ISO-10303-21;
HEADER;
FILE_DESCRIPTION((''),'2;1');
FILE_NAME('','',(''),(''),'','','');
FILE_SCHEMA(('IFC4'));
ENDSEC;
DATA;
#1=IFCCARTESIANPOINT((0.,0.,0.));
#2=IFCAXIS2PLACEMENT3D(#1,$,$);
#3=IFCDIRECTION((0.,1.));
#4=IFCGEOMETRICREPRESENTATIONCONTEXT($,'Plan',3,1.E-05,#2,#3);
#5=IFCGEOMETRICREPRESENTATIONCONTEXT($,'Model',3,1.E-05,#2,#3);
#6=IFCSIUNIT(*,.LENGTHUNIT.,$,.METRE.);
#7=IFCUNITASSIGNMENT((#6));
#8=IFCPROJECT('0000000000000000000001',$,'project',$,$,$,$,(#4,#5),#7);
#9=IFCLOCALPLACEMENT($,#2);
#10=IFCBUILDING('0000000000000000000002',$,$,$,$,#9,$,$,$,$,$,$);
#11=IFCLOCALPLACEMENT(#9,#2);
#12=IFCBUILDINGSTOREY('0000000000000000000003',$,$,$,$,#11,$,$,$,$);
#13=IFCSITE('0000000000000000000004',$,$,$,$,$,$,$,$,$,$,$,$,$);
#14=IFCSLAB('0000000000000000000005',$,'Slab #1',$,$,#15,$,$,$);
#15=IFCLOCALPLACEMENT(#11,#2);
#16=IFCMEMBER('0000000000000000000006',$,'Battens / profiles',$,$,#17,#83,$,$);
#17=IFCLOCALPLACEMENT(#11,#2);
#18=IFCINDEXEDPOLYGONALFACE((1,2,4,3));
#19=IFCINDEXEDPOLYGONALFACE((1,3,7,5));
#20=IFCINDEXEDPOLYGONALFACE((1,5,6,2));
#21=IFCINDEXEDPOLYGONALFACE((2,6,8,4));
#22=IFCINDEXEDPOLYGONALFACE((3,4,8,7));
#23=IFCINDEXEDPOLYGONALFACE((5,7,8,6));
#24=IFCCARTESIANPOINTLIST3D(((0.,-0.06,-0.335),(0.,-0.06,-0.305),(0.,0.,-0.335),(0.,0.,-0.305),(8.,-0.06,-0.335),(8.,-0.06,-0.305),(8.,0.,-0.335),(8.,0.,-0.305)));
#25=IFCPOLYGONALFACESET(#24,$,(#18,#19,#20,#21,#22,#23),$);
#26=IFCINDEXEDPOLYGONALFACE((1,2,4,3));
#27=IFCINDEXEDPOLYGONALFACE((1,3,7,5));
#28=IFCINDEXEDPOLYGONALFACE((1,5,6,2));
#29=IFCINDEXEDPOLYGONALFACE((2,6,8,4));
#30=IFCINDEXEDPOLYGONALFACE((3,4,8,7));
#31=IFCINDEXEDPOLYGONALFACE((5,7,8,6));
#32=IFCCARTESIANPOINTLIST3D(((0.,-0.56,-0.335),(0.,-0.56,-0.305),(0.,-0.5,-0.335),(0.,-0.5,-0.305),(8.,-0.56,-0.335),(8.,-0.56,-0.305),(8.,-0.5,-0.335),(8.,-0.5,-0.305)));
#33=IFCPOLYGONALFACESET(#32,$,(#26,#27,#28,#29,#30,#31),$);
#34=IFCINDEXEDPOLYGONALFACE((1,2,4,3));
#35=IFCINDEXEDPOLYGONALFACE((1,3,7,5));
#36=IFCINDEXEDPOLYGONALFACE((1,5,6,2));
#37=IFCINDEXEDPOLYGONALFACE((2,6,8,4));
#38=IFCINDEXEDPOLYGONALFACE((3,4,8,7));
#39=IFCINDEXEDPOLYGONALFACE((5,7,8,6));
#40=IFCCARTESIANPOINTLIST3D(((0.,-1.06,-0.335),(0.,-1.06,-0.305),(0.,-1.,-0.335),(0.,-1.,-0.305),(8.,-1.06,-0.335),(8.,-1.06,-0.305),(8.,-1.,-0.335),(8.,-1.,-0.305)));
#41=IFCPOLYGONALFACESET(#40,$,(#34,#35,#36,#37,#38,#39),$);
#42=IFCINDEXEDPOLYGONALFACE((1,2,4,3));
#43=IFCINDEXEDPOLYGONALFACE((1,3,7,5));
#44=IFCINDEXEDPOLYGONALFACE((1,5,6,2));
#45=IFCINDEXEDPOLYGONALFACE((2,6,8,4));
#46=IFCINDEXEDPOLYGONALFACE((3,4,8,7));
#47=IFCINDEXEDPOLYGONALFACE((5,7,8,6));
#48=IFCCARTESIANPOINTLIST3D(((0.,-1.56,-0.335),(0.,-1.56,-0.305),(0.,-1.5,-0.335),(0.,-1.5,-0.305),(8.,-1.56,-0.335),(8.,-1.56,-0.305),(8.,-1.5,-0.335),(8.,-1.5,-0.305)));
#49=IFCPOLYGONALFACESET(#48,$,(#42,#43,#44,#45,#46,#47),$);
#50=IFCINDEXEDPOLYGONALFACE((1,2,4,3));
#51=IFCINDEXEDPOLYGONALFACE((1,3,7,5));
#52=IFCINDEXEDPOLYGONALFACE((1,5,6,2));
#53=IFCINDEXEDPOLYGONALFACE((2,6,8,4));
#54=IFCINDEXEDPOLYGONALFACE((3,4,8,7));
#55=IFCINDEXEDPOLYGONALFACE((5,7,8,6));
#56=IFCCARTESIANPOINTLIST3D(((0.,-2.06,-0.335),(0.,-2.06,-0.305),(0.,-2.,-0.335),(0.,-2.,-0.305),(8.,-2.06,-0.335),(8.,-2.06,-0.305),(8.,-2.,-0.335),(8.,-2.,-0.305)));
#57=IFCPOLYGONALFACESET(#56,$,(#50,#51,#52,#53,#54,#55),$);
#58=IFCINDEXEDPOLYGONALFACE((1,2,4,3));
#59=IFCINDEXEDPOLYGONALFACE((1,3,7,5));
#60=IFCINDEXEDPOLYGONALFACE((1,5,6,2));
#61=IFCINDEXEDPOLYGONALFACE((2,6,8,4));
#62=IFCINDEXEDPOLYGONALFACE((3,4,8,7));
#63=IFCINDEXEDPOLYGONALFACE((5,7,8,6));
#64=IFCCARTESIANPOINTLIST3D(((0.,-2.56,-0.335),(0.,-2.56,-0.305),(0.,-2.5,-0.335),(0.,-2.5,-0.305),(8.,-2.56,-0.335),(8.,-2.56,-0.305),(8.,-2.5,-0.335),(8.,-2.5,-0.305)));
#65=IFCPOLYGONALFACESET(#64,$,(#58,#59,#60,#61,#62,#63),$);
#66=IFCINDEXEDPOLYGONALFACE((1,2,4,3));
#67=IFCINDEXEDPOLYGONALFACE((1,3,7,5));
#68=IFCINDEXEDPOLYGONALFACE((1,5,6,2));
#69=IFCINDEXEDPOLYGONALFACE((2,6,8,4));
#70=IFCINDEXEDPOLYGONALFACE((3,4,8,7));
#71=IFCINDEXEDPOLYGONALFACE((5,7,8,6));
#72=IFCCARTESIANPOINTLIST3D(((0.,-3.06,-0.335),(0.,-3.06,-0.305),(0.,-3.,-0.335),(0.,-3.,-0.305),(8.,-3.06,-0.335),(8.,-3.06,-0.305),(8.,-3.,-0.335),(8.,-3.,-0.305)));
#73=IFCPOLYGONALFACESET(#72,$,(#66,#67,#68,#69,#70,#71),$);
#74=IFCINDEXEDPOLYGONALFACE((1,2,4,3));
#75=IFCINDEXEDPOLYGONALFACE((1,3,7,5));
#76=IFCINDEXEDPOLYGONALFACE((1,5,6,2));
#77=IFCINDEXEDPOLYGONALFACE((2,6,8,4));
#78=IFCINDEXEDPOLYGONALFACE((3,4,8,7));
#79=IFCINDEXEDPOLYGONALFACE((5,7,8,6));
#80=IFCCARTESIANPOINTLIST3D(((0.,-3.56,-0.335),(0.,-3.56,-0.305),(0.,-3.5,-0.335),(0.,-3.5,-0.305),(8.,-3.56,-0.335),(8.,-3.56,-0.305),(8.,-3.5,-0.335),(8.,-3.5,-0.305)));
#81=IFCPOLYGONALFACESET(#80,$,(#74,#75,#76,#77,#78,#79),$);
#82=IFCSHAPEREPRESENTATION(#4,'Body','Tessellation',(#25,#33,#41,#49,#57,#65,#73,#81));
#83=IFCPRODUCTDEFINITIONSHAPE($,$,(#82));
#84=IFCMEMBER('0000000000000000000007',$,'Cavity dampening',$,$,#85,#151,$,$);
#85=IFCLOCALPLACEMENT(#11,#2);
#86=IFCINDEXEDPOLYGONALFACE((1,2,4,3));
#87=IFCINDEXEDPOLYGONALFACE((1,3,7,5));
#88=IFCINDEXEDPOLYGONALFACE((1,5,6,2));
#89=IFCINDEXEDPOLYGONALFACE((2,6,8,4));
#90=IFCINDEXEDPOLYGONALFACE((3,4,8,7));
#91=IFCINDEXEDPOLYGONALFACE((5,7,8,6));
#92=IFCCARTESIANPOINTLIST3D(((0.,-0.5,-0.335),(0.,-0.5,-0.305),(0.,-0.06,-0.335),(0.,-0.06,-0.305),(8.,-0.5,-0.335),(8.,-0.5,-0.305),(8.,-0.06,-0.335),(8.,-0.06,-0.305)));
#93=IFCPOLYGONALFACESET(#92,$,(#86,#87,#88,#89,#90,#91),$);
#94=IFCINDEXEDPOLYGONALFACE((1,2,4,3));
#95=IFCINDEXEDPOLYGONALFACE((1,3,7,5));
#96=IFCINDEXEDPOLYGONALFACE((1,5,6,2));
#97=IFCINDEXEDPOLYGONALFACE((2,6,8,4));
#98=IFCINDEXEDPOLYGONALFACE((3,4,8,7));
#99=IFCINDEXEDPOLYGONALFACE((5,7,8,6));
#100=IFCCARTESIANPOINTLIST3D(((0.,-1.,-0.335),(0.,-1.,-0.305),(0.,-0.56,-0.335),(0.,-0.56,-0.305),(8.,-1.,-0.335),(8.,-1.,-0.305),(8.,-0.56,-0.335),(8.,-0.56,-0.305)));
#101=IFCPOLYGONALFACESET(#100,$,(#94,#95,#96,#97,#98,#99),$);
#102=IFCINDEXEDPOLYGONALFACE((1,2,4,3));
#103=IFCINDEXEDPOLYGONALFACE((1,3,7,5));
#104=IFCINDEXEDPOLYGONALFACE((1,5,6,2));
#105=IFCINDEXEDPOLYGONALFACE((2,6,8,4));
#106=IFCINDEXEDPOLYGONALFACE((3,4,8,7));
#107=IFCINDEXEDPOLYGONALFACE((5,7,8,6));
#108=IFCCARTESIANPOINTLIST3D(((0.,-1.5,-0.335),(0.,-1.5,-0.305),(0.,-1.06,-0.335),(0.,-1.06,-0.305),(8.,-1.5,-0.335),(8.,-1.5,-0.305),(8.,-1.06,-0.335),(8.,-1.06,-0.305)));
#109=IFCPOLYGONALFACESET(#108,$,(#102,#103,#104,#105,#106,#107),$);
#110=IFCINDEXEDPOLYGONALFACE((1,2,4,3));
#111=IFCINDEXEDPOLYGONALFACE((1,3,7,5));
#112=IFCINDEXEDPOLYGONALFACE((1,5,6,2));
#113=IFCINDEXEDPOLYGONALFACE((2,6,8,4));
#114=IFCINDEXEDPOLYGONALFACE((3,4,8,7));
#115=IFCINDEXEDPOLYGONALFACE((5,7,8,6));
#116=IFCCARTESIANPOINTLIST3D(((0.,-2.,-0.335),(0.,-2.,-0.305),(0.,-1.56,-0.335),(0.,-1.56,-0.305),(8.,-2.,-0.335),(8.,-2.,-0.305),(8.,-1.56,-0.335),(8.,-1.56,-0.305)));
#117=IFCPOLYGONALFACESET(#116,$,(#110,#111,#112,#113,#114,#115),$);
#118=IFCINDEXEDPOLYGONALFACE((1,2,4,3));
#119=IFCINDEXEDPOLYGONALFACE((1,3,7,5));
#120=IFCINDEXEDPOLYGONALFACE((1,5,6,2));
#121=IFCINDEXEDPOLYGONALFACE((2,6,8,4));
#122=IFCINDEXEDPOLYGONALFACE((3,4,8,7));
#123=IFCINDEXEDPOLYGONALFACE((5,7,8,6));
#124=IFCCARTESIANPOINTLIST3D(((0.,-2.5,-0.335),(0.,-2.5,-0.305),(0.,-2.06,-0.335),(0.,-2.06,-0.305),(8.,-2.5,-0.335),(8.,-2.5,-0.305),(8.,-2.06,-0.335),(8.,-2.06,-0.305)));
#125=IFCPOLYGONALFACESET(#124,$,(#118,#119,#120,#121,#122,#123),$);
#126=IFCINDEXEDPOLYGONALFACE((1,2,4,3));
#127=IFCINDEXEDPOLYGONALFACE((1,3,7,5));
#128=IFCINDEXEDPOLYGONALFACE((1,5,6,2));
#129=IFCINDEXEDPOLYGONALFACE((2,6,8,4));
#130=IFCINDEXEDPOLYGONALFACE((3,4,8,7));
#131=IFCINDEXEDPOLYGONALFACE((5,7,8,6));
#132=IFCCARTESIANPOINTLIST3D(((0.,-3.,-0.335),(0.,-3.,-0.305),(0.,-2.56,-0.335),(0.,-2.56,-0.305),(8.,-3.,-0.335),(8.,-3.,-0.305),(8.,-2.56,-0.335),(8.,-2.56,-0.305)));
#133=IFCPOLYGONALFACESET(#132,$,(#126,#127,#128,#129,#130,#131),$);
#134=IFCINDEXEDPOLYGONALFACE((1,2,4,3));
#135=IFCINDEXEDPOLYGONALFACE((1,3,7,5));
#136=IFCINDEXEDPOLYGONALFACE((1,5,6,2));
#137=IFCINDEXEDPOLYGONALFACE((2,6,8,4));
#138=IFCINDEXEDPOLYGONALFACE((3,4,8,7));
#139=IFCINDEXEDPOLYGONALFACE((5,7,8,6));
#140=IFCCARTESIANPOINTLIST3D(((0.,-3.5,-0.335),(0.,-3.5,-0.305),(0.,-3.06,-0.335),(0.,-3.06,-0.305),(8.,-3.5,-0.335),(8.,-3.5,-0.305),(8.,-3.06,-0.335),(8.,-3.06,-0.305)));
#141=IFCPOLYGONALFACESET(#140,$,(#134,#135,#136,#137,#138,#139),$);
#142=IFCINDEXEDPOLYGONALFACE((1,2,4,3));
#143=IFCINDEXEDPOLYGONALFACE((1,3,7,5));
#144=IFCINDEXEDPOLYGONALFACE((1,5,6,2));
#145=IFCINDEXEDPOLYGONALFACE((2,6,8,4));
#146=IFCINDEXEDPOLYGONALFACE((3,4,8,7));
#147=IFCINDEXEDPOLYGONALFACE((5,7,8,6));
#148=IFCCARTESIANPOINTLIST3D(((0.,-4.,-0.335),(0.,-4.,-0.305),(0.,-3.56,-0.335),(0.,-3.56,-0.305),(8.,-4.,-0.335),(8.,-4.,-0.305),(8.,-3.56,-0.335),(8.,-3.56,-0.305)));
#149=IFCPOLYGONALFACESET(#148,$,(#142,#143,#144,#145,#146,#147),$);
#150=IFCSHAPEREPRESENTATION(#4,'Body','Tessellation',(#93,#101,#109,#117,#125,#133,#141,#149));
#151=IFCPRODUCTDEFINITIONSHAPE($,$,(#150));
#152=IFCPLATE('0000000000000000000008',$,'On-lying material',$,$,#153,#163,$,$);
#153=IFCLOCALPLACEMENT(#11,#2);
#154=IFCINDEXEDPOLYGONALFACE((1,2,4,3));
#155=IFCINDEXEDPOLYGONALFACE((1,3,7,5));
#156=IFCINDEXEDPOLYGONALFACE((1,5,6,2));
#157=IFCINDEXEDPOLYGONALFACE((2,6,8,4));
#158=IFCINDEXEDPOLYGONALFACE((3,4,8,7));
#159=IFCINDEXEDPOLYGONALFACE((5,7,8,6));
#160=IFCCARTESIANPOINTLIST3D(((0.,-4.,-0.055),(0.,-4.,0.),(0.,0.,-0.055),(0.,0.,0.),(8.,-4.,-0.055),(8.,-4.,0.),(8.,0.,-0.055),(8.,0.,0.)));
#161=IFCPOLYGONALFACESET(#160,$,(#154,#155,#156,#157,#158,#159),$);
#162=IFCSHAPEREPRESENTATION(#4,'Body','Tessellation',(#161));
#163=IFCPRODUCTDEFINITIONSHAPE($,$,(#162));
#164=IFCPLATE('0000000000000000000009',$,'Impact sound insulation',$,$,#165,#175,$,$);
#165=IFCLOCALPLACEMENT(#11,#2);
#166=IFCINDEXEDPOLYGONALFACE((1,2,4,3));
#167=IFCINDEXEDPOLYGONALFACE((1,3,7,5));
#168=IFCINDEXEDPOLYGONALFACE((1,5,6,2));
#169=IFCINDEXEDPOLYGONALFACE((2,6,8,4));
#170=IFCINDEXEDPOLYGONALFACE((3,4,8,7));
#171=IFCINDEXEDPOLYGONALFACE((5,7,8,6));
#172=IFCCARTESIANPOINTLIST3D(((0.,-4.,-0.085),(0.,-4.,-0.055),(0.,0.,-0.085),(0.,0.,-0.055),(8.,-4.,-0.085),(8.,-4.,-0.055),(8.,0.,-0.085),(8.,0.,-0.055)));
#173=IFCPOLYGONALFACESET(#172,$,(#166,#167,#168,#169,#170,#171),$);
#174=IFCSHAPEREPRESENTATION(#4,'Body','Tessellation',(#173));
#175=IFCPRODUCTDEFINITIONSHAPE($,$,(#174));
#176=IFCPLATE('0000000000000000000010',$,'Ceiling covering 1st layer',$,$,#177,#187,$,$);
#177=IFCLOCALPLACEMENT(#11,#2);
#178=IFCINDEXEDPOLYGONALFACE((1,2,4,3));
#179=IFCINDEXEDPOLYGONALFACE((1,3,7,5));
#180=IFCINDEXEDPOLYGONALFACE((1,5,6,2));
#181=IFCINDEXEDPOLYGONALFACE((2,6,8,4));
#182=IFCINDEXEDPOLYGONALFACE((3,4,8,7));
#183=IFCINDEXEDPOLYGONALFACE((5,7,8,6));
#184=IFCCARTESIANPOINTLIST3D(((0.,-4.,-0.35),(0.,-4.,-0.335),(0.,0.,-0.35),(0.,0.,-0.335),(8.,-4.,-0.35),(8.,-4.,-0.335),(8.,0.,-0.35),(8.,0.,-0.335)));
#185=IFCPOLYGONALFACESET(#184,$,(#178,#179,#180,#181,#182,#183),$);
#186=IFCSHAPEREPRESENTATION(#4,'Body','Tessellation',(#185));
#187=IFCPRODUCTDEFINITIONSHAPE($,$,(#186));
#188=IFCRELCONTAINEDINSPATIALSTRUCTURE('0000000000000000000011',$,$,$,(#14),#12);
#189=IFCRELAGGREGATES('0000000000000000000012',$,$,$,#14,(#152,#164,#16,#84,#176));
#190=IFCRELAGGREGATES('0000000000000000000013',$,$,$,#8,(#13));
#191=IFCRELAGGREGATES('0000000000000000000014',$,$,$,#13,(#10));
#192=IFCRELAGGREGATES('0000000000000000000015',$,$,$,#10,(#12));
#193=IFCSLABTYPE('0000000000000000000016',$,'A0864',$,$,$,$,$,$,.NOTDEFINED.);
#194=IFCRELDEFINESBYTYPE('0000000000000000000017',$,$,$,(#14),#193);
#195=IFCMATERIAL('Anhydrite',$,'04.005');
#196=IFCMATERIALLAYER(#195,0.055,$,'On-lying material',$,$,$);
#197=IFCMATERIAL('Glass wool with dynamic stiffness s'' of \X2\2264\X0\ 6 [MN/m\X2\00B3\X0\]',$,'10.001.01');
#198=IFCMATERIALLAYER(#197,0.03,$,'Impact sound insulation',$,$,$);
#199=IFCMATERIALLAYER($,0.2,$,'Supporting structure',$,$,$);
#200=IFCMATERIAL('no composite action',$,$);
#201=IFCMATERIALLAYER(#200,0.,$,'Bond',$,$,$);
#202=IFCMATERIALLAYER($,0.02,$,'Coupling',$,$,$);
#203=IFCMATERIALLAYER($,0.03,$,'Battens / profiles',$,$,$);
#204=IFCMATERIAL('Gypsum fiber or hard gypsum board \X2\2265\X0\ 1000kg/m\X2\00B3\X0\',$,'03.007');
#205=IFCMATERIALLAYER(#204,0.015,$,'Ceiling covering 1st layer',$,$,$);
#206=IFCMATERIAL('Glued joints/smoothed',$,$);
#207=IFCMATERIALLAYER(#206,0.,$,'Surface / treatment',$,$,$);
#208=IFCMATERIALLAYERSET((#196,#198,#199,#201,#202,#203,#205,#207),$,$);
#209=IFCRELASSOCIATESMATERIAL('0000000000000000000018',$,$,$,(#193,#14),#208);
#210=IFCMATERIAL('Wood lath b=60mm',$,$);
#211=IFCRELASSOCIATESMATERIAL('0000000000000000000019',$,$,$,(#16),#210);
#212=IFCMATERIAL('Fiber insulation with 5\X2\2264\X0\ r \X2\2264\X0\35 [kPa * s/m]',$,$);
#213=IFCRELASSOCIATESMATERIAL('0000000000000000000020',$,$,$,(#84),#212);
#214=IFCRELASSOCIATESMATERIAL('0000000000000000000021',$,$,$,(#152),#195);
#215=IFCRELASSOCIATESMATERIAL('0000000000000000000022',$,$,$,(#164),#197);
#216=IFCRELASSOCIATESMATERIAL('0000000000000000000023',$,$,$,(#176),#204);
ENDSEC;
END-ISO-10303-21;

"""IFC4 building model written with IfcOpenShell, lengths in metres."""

from ifc_helpers import new_model, si_unit, direction, frame, frame_2d, origin, origin_with_axes, place, context, project, spatial, rectangle, extrude, material, layer, layer_set, type_object, element, aggregate, save


model = new_model("IFC4")

# Units and contexts
plan_context = context("Plan", 3, precision=1e-05, world=origin(), true_north=direction((0.0, 1.0)))
model_context = context("Model", 3, precision=1e-05, world=origin(), true_north=direction((0.0, 1.0)))
ifc_project = project(units=[si_unit("LENGTHUNIT", "METRE")], contexts=[plan_context, model_context])

# Site, building, storey
site = spatial("IfcSite", under=ifc_project)
building_placement = place(None, origin())
building = spatial("IfcBuilding", under=site, at=building_placement)
storey_placement = place(building_placement, origin())
storey = spatial("IfcBuildingStorey", under=building, at=storey_placement)

# Slab, members, plates
ifc_material_1 = material(Name="Anhydrite", Category="04.005")
ifc_layer_1 = layer(ifc_material_1, 0.055, Name="On-lying material")
ifc_material_2 = material(Name="Glass wool with dynamic stiffness s' of ≤ 6 [MN/m³]", Category="10.001.01")
ifc_layer_2 = layer(ifc_material_2, 0.03, Name="Impact sound insulation")
ifc_layer_3 = layer(None, 0.2, Name="Supporting structure")
ifc_material_3 = material(Name="no composite action")
ifc_layer_4 = layer(ifc_material_3, 0.0, Name="Bond")
ifc_layer_5 = layer(None, 0.02, Name="Coupling")
ifc_layer_6 = layer(None, 0.03, Name="Battens / profiles")
ifc_material_4 = material(Name="Gypsum fiber or hard gypsum board ≥ 1000kg/m³", Category="03.007")
ifc_layer_7 = layer(ifc_material_4, 0.015, Name="Ceiling covering 1st layer")
ifc_material_5 = material(Name="Glued joints/smoothed")
ifc_layer_8 = layer(ifc_material_5, 0.0, Name="Surface / treatment")
ifc_layer_set = layer_set([ifc_layer_1, ifc_layer_2, ifc_layer_3, ifc_layer_4, ifc_layer_5, ifc_layer_6, ifc_layer_7, ifc_layer_8])
slab_type = type_object("IfcSlabType", Name="A0864", PredefinedType="NOTDEFINED", material=ifc_layer_set)
slab_placement = place(None, frame((0.0, 0.0, 0.0), z_axis=(0.0, 0.0, -1.0), x_axis=(1.0, 0.0, 0.0)))
slab = element("IfcSlab", 1, at=slab_placement, inside=storey, type_object=slab_type, material=ifc_layer_set, Name="Slab #1")
ifc_material_6 = material(Name="Wood lath b=60mm")
member_1_placement = place(slab_placement, origin())
member_1 = element("IfcMember", 2, at=member_1_placement, material=ifc_material_6, Name="Battens / profiles", context=plan_context, shape_type="SweptSolid", body=[
    extrude(rectangle(XDim=0.06, YDim=0.03, at=frame_2d((0.03, 0.015), x_axis=(1.0, 0.0))), frame((0.0, 0.0, 0.305), z_axis=(1.0, 0.0, 0.0), x_axis=(0.0, 1.0, 0.0)), (0.0, 0.0, 1.0), 8.0),
    extrude(rectangle(XDim=0.06, YDim=0.03, at=frame_2d((0.03, 0.015), x_axis=(1.0, 0.0))), frame((0.0, 0.5, 0.305), z_axis=(1.0, 0.0, 0.0), x_axis=(0.0, 1.0, 0.0)), (0.0, 0.0, 1.0), 8.0),
    extrude(rectangle(XDim=0.06, YDim=0.03, at=frame_2d((0.03, 0.015), x_axis=(1.0, 0.0))), frame((0.0, 1.0, 0.305), z_axis=(1.0, 0.0, 0.0), x_axis=(0.0, 1.0, 0.0)), (0.0, 0.0, 1.0), 8.0),
    extrude(rectangle(XDim=0.06, YDim=0.03, at=frame_2d((0.03, 0.015), x_axis=(1.0, 0.0))), frame((0.0, 1.5, 0.305), z_axis=(1.0, 0.0, 0.0), x_axis=(0.0, 1.0, 0.0)), (0.0, 0.0, 1.0), 8.0),
    extrude(rectangle(XDim=0.06, YDim=0.03, at=frame_2d((0.03, 0.015), x_axis=(1.0, 0.0))), frame((0.0, 2.0, 0.305), z_axis=(1.0, 0.0, 0.0), x_axis=(0.0, 1.0, 0.0)), (0.0, 0.0, 1.0), 8.0),
    extrude(rectangle(XDim=0.06, YDim=0.03, at=frame_2d((0.03, 0.015), x_axis=(1.0, 0.0))), frame((0.0, 2.5, 0.305), z_axis=(1.0, 0.0, 0.0), x_axis=(0.0, 1.0, 0.0)), (0.0, 0.0, 1.0), 8.0),
    extrude(rectangle(XDim=0.06, YDim=0.03, at=frame_2d((0.03, 0.015), x_axis=(1.0, 0.0))), frame((0.0, 3.0, 0.305), z_axis=(1.0, 0.0, 0.0), x_axis=(0.0, 1.0, 0.0)), (0.0, 0.0, 1.0), 8.0),
    extrude(rectangle(XDim=0.06, YDim=0.03, at=frame_2d((0.03, 0.015), x_axis=(1.0, 0.0))), frame((0.0, 3.5, 0.305), z_axis=(1.0, 0.0, 0.0), x_axis=(0.0, 1.0, 0.0)), (0.0, 0.0, 1.0), 8.0),
])
ifc_material_7 = material(Name="Fiber insulation with 5≤ r ≤35 [kPa * s/m]")
member_2_placement = place(slab_placement, origin())
member_2 = element("IfcMember", 3, at=member_2_placement, material=ifc_material_7, Name="Cavity dampening", context=plan_context, shape_type="SweptSolid", body=[
    extrude(rectangle(XDim=0.44, YDim=0.03, at=frame_2d((0.22, 0.015), x_axis=(1.0, 0.0))), frame((0.0, 0.06, 0.305), z_axis=(1.0, 0.0, 0.0), x_axis=(0.0, 1.0, 0.0)), (0.0, 0.0, 1.0), 8.0),
    extrude(rectangle(XDim=0.44, YDim=0.03, at=frame_2d((0.22, 0.015), x_axis=(1.0, 0.0))), frame((0.0, 0.56, 0.305), z_axis=(1.0, 0.0, 0.0), x_axis=(0.0, 1.0, 0.0)), (0.0, 0.0, 1.0), 8.0),
    extrude(rectangle(XDim=0.44, YDim=0.03, at=frame_2d((0.22, 0.015), x_axis=(1.0, 0.0))), frame((0.0, 1.06, 0.305), z_axis=(1.0, 0.0, 0.0), x_axis=(0.0, 1.0, 0.0)), (0.0, 0.0, 1.0), 8.0),
    extrude(rectangle(XDim=0.44, YDim=0.03, at=frame_2d((0.22, 0.015), x_axis=(1.0, 0.0))), frame((0.0, 1.56, 0.305), z_axis=(1.0, 0.0, 0.0), x_axis=(0.0, 1.0, 0.0)), (0.0, 0.0, 1.0), 8.0),
    extrude(rectangle(XDim=0.44, YDim=0.03, at=frame_2d((0.22, 0.015), x_axis=(1.0, 0.0))), frame((0.0, 2.06, 0.305), z_axis=(1.0, 0.0, 0.0), x_axis=(0.0, 1.0, 0.0)), (0.0, 0.0, 1.0), 8.0),
    extrude(rectangle(XDim=0.44, YDim=0.03, at=frame_2d((0.22, 0.015), x_axis=(1.0, 0.0))), frame((0.0, 2.56, 0.305), z_axis=(1.0, 0.0, 0.0), x_axis=(0.0, 1.0, 0.0)), (0.0, 0.0, 1.0), 8.0),
    extrude(rectangle(XDim=0.44, YDim=0.03, at=frame_2d((0.22, 0.015), x_axis=(1.0, 0.0))), frame((0.0, 3.06, 0.305), z_axis=(1.0, 0.0, 0.0), x_axis=(0.0, 1.0, 0.0)), (0.0, 0.0, 1.0), 8.0),
    extrude(rectangle(XDim=0.44, YDim=0.03, at=frame_2d((0.22, 0.015), x_axis=(1.0, 0.0))), frame((0.0, 3.56, 0.305), z_axis=(1.0, 0.0, 0.0), x_axis=(0.0, 1.0, 0.0)), (0.0, 0.0, 1.0), 8.0),
])
plate_1_placement = place(slab_placement, origin())
plate_1 = element("IfcPlate", 4, at=plate_1_placement, material=ifc_material_1, Name="On-lying material", context=plan_context, shape_type="SweptSolid", body=[
    extrude(rectangle(XDim=8.0, YDim=4.0, at=frame_2d((4.0, 2.0), x_axis=(1.0, 0.0))), origin_with_axes(), (0.0, 0.0, 1.0), 0.055),
])
plate_2_placement = place(slab_placement, origin())
plate_2 = element("IfcPlate", 5, at=plate_2_placement, material=ifc_material_2, Name="Impact sound insulation", context=plan_context, shape_type="SweptSolid", body=[
    extrude(rectangle(XDim=8.0, YDim=4.0, at=frame_2d((4.0, 2.0), x_axis=(1.0, 0.0))), frame((0.0, 0.0, 0.055), z_axis=(0.0, 0.0, 1.0), x_axis=(1.0, 0.0, 0.0)), (0.0, 0.0, 1.0), 0.03),
])
plate_3_placement = place(slab_placement, origin())
plate_3 = element("IfcPlate", 6, at=plate_3_placement, material=ifc_material_4, Name="Ceiling covering 1st layer", context=plan_context, shape_type="SweptSolid", body=[
    extrude(rectangle(XDim=8.0, YDim=4.0, at=frame_2d((4.0, 2.0), x_axis=(1.0, 0.0))), frame((0.0, 0.0, 0.335), z_axis=(0.0, 0.0, 1.0), x_axis=(1.0, 0.0, 0.0)), (0.0, 0.0, 1.0), 0.015),
])
aggregate(slab, [plate_1, plate_2, member_1, member_2, plate_3])

save(model, "model.ifc")
